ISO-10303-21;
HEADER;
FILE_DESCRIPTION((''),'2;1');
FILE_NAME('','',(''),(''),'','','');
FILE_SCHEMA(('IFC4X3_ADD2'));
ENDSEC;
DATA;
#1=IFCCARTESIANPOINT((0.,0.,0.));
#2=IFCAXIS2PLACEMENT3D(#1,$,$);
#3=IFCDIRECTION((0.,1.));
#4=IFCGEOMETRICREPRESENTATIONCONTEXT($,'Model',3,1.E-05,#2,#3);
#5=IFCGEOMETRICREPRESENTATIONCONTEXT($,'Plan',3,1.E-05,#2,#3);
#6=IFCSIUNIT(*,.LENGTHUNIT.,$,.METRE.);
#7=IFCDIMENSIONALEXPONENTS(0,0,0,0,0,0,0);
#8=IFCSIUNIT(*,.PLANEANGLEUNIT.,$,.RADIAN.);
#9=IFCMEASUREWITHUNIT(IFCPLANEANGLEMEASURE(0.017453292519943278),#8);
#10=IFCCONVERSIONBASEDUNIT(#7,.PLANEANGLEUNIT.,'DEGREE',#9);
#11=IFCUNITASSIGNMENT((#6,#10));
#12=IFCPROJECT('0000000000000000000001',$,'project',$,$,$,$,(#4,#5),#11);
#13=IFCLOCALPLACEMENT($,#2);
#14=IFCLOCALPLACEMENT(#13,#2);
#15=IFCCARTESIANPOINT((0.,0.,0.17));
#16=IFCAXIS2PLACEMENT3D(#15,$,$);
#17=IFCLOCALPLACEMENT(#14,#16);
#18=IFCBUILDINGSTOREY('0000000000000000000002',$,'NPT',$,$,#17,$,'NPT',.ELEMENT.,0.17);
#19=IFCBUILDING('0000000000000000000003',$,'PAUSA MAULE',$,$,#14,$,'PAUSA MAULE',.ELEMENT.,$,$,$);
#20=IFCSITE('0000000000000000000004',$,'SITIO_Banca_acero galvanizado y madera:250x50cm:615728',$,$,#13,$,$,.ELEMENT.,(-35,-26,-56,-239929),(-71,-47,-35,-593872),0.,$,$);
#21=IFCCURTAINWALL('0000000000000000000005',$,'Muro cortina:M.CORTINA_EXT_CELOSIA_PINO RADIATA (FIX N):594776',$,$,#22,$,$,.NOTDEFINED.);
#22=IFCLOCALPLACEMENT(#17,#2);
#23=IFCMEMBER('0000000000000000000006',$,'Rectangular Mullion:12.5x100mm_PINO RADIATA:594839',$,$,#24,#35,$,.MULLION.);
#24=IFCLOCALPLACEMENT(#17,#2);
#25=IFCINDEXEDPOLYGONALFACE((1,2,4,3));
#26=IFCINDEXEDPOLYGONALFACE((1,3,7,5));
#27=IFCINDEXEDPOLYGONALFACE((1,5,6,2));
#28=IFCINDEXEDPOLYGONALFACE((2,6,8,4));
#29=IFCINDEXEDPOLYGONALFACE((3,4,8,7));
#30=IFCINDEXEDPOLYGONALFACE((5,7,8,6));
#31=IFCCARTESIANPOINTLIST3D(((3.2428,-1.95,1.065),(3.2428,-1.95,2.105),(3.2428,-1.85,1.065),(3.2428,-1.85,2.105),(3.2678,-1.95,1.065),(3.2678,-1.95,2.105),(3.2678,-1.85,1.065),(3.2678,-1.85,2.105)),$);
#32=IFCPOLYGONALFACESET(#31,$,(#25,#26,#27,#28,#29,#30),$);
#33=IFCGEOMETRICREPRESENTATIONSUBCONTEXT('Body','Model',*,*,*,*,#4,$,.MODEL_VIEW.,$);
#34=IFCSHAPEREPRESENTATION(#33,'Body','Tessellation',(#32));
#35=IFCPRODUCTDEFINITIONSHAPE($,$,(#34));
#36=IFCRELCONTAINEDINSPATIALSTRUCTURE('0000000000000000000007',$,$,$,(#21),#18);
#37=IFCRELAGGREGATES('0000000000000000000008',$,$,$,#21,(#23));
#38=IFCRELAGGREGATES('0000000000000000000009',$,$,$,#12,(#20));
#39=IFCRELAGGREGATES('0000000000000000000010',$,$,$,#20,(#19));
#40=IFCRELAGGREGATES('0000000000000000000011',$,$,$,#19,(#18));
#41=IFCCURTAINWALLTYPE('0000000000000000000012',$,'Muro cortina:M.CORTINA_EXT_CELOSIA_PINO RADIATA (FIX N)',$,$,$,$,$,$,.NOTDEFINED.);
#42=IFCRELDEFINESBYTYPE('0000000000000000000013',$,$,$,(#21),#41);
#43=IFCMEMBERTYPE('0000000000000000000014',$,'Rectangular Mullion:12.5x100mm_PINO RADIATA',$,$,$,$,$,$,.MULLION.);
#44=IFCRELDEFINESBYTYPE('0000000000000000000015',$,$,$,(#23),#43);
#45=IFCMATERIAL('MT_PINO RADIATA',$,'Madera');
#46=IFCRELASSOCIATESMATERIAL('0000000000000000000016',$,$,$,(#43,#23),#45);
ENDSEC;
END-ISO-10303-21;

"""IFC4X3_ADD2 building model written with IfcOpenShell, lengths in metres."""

from ifc_helpers import new_model, entity, si_unit, converted_unit, direction, frame, frame_2d, origin, origin_2d_with_axis, place, context, subcontext, project, spatial, rectangle, extrude, source, transform, mapped, material, material_profile, profile_set, profile_usage, type_object, type_shapes, element, aggregate, save


model = new_model("IFC4X3_ADD2")

# Units and contexts
model_context = context("Model", 3, precision=1e-05, world=origin(), true_north=direction((0.0, 1.0)))
plan_context = context("Plan", 3, precision=1e-05, world=origin(), true_north=direction((0.0, 1.0)))
body_context = subcontext(model_context, "Body", "Model", "MODEL_VIEW")
ifc_project = project(units=[si_unit("LENGTHUNIT", "METRE"), converted_unit("PLANEANGLEUNIT", "DEGREE", entity("IfcPlaneAngleMeasure", 0.017453292519943278), si_unit("PLANEANGLEUNIT", "RADIAN"), dimensions=[0, 0, 0, 0, 0, 0, 0])], contexts=[model_context, plan_context])

# Site, building, storey
site_placement = place(None, origin())
site = spatial("IfcSite", under=ifc_project, at=site_placement, Name="SITIO_Banca_acero galvanizado y madera:250x50cm:615728", CompositionType="ELEMENT", RefLatitude=(-35, -26, -56, -239929), RefLongitude=(-71, -47, -35, -593872), RefElevation=0.0)
building_placement = place(site_placement, origin())
building = spatial("IfcBuilding", under=site, at=building_placement, Name="PAUSA MAULE", LongName="PAUSA MAULE", CompositionType="ELEMENT")
storey_placement = place(building_placement, frame((0.0, 0.0, 0.17)))
storey = spatial("IfcBuildingStorey", under=building, at=storey_placement, Name="NPT", LongName="NPT", CompositionType="ELEMENT", Elevation=0.17)

# Curtain wall
curtain_wall_type = type_object("IfcCurtainWallType", Name="Muro cortina:M.CORTINA_EXT_CELOSIA_PINO RADIATA (FIX N)", PredefinedType="NOTDEFINED")
ifc_material = material(Name="MT_PINO RADIATA", Category="Madera")
ifc_material_profile = material_profile(ifc_material, rectangle(XDim=0.025, YDim=0.1, at=frame_2d((0.0, 0.0), x_axis=(1.0, 0.0))), Name="12.5x100mm_PINO RADIATA")
ifc_profile_set = profile_set([ifc_material_profile], Name="12.5x100mm_PINO RADIATA")
ifc_profile_usage = profile_usage(ifc_profile_set)
curtain_wall_1_placement = place(storey_placement, frame((0.0, 0.0, -0.17)))
curtain_wall_1 = element("IfcCurtainWall", 1, at=curtain_wall_1_placement, inside=storey, type_object=curtain_wall_type, Name="Muro cortina:M.CORTINA_EXT_CELOSIA_PINO RADIATA (FIX N):594776", PredefinedType="NOTDEFINED")

# Member
member_type_1 = type_object("IfcMemberType", Name="Rectangular Mullion:12.5x100mm_PINO RADIATA", PredefinedType="MULLION", material=ifc_profile_set)
shared_shape_1 = source(origin(), body_context, "Body", "SweptSolid", [
    extrude(rectangle(XDim=0.025, YDim=0.1, at=origin_2d_with_axis()), frame((0.0, 0.0, -1.04), z_axis=(0.0, 0.0, 1.0), x_axis=(-1.0, 0.0, 0.0)), (0.0, 0.0, 1.0), 1.04),
])
type_shapes(member_type_1, [shared_shape_1])
member_1_placement = place(curtain_wall_1_placement, frame((3.2553, -1.9, 1.235), z_axis=(0.0, 0.0, -1.0), x_axis=(1.0, 0.0, 0.0)))
member_1 = element("IfcMember", 2, at=member_1_placement, type_object=member_type_1, material=ifc_profile_usage, Name="Rectangular Mullion:12.5x100mm_PINO RADIATA:594839", PredefinedType="MULLION", context=body_context, shape_type="MappedRepresentation", body=[
    mapped(shared_shape_1, transform((0.0, 0.0, 0.0), scale=1.0)),
])
aggregate(curtain_wall_1, [member_1])

save(model, "model.ifc")
